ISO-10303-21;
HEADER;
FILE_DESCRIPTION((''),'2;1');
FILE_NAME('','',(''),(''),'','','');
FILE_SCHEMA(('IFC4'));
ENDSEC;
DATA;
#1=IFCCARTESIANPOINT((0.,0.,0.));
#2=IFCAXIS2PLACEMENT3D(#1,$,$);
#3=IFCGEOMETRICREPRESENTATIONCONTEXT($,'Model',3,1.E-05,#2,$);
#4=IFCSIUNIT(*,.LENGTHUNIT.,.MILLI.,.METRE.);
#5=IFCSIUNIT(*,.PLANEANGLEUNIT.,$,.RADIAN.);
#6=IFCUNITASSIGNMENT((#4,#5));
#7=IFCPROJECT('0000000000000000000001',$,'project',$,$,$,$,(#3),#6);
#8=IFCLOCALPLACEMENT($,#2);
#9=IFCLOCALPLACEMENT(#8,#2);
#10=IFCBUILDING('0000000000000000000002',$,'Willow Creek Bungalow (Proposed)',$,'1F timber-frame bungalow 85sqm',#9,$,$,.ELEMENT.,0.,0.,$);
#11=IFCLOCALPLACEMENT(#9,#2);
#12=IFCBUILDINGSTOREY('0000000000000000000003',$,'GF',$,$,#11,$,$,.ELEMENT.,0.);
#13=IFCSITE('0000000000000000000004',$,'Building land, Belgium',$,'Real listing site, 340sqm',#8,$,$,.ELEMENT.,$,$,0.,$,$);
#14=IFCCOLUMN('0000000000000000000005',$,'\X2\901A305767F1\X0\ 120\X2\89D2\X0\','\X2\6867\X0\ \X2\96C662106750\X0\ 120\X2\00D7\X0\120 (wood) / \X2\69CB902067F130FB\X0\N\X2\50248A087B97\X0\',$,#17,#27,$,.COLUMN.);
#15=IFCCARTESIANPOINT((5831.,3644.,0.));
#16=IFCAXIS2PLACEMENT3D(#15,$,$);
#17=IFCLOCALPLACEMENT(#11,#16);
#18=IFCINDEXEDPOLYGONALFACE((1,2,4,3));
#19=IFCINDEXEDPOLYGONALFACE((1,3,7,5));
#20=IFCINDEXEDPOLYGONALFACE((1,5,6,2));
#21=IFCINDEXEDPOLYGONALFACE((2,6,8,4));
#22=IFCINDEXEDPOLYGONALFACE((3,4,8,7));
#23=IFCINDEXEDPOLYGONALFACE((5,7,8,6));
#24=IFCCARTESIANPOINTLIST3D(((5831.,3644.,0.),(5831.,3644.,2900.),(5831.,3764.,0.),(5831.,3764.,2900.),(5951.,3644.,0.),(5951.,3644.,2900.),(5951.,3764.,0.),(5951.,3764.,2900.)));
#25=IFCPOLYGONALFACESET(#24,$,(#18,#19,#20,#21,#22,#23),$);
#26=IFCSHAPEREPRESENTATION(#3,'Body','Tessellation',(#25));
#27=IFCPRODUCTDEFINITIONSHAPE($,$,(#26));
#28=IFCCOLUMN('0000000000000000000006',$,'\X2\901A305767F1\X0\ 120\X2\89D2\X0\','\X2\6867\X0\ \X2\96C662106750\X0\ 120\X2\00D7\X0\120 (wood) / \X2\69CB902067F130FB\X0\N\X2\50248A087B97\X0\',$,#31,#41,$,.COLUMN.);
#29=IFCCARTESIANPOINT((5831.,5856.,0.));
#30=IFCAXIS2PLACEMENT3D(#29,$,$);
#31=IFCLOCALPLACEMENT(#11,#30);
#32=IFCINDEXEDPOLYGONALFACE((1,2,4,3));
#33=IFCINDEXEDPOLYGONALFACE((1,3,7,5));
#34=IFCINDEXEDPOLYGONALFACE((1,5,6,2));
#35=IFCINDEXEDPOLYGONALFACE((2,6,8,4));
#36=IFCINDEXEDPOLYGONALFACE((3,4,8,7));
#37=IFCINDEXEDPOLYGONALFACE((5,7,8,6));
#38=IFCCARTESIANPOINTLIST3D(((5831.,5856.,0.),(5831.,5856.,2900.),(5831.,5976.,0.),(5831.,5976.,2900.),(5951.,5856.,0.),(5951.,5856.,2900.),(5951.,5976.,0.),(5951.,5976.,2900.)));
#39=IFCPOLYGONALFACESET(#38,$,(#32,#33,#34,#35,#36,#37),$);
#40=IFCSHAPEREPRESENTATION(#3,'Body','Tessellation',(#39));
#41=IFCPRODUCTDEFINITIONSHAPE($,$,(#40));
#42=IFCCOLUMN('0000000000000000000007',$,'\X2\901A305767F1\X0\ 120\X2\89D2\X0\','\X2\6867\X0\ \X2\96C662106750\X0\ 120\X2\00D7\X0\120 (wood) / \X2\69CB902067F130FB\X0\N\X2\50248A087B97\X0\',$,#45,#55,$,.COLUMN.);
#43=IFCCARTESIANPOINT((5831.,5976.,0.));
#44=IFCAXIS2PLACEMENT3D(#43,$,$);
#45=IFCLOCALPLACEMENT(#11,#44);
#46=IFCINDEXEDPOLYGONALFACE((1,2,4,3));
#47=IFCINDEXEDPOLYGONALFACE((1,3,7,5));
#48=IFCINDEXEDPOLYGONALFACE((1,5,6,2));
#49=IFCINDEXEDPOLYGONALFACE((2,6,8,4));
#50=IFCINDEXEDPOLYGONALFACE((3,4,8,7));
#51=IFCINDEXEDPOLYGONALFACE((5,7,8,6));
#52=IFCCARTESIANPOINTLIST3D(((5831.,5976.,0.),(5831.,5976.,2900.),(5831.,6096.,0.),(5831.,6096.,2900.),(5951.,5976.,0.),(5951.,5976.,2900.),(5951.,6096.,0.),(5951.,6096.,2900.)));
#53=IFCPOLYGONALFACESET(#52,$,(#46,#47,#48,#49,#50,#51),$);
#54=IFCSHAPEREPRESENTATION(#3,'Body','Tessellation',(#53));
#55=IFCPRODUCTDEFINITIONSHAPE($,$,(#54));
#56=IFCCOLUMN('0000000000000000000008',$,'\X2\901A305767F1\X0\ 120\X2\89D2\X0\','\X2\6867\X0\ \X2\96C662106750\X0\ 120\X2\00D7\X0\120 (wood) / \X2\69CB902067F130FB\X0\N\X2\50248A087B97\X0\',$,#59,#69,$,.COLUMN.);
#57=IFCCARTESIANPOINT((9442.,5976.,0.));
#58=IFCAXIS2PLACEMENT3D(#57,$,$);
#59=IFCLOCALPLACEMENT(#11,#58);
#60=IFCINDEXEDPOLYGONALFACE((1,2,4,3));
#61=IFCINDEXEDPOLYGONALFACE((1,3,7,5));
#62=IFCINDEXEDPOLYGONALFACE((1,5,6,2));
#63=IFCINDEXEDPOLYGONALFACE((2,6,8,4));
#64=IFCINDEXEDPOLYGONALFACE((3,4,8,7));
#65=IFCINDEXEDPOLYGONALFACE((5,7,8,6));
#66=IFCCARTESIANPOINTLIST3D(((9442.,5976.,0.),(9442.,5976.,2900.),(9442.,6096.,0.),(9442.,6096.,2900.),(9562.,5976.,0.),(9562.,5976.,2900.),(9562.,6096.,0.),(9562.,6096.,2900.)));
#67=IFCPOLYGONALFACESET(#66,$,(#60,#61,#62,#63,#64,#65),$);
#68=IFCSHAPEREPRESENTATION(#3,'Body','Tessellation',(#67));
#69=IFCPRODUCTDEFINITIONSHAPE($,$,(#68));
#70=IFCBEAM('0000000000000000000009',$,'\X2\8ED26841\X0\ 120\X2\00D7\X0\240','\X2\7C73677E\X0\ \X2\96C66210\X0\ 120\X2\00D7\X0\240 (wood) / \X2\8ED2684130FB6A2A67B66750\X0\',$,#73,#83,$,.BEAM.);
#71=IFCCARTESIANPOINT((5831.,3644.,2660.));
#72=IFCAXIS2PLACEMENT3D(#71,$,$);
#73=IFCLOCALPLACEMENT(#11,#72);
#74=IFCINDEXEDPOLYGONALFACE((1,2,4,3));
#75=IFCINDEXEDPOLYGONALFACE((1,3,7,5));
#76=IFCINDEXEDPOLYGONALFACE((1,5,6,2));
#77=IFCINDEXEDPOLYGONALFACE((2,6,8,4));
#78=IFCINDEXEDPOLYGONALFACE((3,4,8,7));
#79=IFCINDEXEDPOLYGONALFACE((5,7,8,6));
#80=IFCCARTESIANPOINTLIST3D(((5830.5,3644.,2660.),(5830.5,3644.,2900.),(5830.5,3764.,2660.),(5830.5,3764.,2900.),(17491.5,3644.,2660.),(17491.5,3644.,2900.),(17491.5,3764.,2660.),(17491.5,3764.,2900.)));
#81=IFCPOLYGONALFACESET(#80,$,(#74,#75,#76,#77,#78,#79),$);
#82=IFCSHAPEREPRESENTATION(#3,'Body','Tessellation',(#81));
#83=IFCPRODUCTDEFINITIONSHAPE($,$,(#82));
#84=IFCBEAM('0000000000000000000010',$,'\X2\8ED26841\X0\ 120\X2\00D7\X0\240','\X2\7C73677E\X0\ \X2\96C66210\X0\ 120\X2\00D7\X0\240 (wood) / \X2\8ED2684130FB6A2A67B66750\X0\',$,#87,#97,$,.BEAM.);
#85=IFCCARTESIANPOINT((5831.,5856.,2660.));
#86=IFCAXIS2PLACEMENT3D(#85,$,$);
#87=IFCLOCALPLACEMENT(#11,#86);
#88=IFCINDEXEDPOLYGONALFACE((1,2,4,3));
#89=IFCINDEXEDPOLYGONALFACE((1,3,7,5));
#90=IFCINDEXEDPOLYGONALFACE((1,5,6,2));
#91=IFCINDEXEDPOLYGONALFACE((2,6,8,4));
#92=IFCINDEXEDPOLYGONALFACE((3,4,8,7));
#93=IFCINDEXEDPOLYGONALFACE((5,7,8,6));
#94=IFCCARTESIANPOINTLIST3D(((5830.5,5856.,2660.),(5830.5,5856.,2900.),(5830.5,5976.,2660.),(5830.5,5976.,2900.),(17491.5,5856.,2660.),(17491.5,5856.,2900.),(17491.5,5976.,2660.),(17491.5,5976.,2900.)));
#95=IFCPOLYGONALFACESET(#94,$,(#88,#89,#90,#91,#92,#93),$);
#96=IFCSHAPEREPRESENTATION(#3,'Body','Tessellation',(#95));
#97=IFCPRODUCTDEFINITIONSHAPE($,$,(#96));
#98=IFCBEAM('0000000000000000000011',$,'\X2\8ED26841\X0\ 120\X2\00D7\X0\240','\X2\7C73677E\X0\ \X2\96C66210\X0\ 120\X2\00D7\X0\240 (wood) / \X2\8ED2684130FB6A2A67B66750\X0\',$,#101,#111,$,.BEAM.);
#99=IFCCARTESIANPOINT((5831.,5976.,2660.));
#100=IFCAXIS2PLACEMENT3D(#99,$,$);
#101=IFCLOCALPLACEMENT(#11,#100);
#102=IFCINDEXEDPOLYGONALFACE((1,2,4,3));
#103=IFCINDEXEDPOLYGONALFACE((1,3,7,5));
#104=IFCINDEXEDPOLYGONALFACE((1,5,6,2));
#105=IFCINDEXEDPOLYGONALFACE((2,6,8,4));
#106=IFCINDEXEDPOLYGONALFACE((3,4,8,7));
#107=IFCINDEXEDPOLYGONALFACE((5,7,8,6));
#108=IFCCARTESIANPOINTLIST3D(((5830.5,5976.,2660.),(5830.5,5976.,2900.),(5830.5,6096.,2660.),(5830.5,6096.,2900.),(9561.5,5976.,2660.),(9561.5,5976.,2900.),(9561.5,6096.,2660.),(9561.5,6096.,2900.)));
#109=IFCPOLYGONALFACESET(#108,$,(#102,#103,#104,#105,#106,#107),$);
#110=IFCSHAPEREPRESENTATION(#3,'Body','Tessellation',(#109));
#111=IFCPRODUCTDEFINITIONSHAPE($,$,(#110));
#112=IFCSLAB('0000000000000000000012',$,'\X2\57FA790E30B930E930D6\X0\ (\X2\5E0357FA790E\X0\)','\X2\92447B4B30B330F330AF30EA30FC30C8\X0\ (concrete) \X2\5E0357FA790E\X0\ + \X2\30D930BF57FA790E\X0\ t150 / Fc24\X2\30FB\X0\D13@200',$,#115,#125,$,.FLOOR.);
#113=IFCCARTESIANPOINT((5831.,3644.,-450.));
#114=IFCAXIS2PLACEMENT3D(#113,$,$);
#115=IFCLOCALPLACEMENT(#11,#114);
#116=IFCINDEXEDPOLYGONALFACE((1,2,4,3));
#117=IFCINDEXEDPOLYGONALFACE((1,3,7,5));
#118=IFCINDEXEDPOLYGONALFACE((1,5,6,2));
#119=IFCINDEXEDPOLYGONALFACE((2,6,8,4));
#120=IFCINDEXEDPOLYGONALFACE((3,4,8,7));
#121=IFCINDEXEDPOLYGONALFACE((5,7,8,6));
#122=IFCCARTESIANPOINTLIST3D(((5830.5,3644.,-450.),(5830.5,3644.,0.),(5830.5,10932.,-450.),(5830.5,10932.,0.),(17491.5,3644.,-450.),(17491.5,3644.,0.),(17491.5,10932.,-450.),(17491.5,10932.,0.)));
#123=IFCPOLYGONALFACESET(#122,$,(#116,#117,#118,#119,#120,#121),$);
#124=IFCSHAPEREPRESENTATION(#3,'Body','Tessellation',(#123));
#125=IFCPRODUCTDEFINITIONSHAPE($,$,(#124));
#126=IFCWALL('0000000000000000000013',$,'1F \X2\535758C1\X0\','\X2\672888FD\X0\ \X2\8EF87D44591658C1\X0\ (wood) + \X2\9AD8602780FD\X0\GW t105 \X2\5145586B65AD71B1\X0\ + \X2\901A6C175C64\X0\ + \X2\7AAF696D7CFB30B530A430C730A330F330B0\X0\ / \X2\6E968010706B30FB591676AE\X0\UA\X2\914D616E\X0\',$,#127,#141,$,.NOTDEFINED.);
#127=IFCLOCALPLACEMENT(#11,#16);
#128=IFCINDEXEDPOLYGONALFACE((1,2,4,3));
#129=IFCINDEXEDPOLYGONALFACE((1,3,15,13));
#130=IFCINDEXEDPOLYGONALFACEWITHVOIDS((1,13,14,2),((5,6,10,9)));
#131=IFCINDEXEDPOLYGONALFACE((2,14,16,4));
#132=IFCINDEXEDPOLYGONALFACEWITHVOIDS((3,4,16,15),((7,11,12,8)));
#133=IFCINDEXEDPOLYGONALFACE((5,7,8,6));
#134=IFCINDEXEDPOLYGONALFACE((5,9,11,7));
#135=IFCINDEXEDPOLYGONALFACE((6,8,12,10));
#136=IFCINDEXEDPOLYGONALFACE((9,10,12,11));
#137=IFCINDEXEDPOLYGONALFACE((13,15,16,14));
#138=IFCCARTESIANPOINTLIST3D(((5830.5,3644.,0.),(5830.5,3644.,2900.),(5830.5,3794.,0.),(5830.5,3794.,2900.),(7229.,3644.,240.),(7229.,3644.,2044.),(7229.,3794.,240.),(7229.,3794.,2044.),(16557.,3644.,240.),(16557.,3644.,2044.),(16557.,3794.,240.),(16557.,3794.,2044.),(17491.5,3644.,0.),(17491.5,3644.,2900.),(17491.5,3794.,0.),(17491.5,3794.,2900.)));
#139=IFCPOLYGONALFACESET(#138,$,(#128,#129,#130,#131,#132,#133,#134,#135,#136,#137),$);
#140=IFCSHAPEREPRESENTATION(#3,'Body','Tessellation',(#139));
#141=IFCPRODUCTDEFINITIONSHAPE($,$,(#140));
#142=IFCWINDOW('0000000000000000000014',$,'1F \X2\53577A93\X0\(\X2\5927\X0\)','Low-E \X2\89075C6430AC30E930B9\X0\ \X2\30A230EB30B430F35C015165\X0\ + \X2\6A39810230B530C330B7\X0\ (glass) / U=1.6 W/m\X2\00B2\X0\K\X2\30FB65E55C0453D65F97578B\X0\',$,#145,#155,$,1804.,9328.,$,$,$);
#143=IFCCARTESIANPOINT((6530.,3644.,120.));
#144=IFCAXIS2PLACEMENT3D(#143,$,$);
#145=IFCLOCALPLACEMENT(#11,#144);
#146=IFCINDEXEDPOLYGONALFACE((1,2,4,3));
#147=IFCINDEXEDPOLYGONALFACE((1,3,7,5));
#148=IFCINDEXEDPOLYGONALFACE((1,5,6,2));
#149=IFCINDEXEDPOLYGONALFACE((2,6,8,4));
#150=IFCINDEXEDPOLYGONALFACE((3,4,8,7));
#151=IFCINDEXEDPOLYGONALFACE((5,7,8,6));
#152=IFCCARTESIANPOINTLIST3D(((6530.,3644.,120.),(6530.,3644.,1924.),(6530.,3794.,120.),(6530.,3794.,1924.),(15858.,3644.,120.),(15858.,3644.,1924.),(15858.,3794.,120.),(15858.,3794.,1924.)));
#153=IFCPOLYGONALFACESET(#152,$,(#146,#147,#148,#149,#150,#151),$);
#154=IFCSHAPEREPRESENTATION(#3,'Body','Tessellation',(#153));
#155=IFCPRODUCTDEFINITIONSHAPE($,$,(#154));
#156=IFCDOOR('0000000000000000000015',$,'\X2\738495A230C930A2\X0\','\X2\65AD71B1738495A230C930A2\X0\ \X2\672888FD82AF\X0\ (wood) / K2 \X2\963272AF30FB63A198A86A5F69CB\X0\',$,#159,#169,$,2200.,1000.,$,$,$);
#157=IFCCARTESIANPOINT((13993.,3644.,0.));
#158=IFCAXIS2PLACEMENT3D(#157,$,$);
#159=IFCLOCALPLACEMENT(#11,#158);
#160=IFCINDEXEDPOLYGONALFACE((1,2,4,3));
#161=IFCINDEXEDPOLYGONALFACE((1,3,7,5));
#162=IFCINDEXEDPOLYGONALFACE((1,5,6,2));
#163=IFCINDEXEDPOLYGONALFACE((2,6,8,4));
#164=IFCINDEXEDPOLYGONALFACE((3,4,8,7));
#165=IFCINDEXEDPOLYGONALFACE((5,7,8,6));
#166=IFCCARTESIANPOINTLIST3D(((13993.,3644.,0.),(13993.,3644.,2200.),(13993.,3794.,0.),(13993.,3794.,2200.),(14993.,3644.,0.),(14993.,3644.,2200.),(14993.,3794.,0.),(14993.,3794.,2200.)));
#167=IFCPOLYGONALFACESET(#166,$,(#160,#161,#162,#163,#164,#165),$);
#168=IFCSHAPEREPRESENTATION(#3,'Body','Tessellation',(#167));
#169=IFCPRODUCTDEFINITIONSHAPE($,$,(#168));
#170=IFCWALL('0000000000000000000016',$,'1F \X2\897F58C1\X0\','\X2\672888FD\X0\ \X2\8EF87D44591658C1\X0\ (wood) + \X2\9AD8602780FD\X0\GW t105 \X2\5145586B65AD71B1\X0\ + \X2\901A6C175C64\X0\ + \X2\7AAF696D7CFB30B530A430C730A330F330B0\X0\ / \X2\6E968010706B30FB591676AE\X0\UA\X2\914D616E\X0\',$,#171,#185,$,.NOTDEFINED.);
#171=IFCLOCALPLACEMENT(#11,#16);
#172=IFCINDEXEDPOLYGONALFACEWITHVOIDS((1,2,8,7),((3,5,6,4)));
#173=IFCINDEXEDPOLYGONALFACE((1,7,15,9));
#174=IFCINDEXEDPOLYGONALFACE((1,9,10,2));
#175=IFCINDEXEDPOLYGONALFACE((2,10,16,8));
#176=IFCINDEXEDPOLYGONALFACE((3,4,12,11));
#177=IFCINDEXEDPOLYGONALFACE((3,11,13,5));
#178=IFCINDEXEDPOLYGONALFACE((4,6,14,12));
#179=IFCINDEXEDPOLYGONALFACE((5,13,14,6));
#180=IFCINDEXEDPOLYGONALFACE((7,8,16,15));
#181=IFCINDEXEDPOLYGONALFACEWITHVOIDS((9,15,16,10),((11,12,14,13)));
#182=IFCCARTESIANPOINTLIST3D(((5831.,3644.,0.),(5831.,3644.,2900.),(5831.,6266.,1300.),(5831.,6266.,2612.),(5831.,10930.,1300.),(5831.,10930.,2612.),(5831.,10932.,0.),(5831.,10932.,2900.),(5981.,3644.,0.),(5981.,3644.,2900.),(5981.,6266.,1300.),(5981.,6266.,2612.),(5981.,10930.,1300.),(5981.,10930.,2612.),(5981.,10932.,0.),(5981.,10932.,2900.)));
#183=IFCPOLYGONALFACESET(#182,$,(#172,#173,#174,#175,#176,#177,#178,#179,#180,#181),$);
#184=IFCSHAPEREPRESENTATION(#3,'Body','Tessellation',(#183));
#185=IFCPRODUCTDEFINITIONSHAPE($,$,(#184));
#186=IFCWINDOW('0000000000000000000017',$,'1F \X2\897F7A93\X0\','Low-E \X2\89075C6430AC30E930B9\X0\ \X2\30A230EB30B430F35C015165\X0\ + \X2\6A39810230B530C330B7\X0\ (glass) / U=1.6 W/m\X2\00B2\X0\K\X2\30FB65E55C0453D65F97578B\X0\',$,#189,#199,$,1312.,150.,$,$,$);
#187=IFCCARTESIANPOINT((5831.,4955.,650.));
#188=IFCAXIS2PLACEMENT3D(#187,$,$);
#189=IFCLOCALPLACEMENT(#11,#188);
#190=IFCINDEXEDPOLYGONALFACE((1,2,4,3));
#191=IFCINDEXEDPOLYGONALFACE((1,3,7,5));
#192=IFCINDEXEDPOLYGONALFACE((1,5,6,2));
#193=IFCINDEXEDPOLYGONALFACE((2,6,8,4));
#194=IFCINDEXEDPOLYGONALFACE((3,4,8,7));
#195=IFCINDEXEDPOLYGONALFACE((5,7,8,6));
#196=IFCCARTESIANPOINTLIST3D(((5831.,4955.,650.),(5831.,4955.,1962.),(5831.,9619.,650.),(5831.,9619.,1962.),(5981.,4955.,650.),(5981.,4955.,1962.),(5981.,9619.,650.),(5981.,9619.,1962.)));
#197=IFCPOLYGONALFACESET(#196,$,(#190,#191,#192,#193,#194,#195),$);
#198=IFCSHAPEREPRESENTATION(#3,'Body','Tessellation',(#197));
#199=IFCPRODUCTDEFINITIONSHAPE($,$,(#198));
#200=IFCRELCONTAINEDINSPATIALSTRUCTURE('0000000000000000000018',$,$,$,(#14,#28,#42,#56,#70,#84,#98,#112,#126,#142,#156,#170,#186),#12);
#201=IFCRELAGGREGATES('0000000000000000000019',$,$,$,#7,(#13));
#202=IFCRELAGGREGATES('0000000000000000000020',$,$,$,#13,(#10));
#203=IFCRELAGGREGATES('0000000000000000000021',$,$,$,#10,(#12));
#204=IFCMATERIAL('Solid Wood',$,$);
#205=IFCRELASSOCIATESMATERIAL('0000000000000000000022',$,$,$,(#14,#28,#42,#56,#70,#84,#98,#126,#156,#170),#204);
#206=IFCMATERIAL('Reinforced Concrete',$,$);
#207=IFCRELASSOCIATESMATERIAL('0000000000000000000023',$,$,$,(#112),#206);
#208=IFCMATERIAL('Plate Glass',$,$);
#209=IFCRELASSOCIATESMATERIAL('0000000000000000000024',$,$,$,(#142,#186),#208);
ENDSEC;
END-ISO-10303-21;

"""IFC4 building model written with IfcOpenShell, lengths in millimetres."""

from ifc_helpers import new_model, si_unit, frame, frame_2d, origin, place, context, project, spatial, rectangle, extrude, material, element, fill, save


model = new_model("IFC4")

# Units and contexts
model_context = context("Model", 3, precision=1e-05, world=origin())
ifc_project = project(units=[si_unit("LENGTHUNIT", "METRE", prefix="MILLI"), si_unit("PLANEANGLEUNIT", "RADIAN")], contexts=[model_context])

# Site, building, storey
site_placement = place(None, origin())
site = spatial("IfcSite", under=ifc_project, at=site_placement, Name="Building land, Belgium", ObjectType="Real listing site, 340sqm", CompositionType="ELEMENT", RefElevation=0.0)
building_placement = place(site_placement, origin())
building = spatial("IfcBuilding", under=site, at=building_placement, Name="Willow Creek Bungalow (Proposed)", ObjectType="1F timber-frame bungalow 85sqm", CompositionType="ELEMENT", ElevationOfRefHeight=0.0, ElevationOfTerrain=0.0)
storey_placement = place(building_placement, origin())
storey = spatial("IfcBuildingStorey", under=building, at=storey_placement, Name="GF", CompositionType="ELEMENT", Elevation=0.0)

# Columns
ifc_material_1 = material(Name="Solid Wood")
column_1_placement = place(storey_placement, frame((5831.0, 3644.0, 0.0)))
element("IfcColumn", 1, at=column_1_placement, inside=storey, material=ifc_material_1, Name="通し柱 120角", Description="桧 集成材 120×120 (wood) / 構造柱・N値計算", PredefinedType="COLUMN", context=model_context, shape_type="SweptSolid", body=[
    extrude(rectangle(XDim=120.0, YDim=120.0, at=frame_2d((60.0, 60.0))), frame((5831.0, 3644.0, 0.0)), (0.0, 0.0, 1.0), 2900.0),
])
column_2_placement = place(storey_placement, frame((5831.0, 5856.0, 0.0)))
element("IfcColumn", 2, at=column_2_placement, inside=storey, material=ifc_material_1, Name="通し柱 120角", Description="桧 集成材 120×120 (wood) / 構造柱・N値計算", PredefinedType="COLUMN", context=model_context, shape_type="SweptSolid", body=[
    extrude(rectangle(XDim=120.0, YDim=120.0, at=frame_2d((60.0, 60.0))), frame((5831.0, 5856.0, 0.0)), (0.0, 0.0, 1.0), 2900.0),
])
column_3_placement = place(storey_placement, frame((5831.0, 5976.0, 0.0)))
element("IfcColumn", 3, at=column_3_placement, inside=storey, material=ifc_material_1, Name="通し柱 120角", Description="桧 集成材 120×120 (wood) / 構造柱・N値計算", PredefinedType="COLUMN", context=model_context, shape_type="SweptSolid", body=[
    extrude(rectangle(XDim=120.0, YDim=120.0, at=frame_2d((60.0, 60.0))), frame((5831.0, 5976.0, 0.0)), (0.0, 0.0, 1.0), 2900.0),
])
column_4_placement = place(storey_placement, frame((9442.0, 5976.0, 0.0)))
element("IfcColumn", 4, at=column_4_placement, inside=storey, material=ifc_material_1, Name="通し柱 120角", Description="桧 集成材 120×120 (wood) / 構造柱・N値計算", PredefinedType="COLUMN", context=model_context, shape_type="SweptSolid", body=[
    extrude(rectangle(XDim=120.0, YDim=120.0, at=frame_2d((60.0, 60.0))), frame((9442.0, 5976.0, 0.0)), (0.0, 0.0, 1.0), 2900.0),
])

# Beams
beam_1_placement = place(storey_placement, frame((5831.0, 3644.0, 2660.0)))
element("IfcBeam", 5, at=beam_1_placement, inside=storey, material=ifc_material_1, Name="軒桁 120×240", Description="米松 集成 120×240 (wood) / 軒桁・横架材", PredefinedType="BEAM", context=model_context, shape_type="SweptSolid", body=[
    extrude(rectangle(XDim=11661.0, YDim=120.0, at=frame_2d((5830.0, 60.0))), frame((5831.0, 3644.0, 2660.0)), (0.0, 0.0, 1.0), 240.0),
])
beam_2_placement = place(storey_placement, frame((5831.0, 5856.0, 2660.0)))
element("IfcBeam", 6, at=beam_2_placement, inside=storey, material=ifc_material_1, Name="軒桁 120×240", Description="米松 集成 120×240 (wood) / 軒桁・横架材", PredefinedType="BEAM", context=model_context, shape_type="SweptSolid", body=[
    extrude(rectangle(XDim=11661.0, YDim=120.0, at=frame_2d((5830.0, 60.0))), frame((5831.0, 5856.0, 2660.0)), (0.0, 0.0, 1.0), 240.0),
])
beam_3_placement = place(storey_placement, frame((5831.0, 5976.0, 2660.0)))
element("IfcBeam", 7, at=beam_3_placement, inside=storey, material=ifc_material_1, Name="軒桁 120×240", Description="米松 集成 120×240 (wood) / 軒桁・横架材", PredefinedType="BEAM", context=model_context, shape_type="SweptSolid", body=[
    extrude(rectangle(XDim=3731.0, YDim=120.0, at=frame_2d((1865.0, 60.0))), frame((5831.0, 5976.0, 2660.0)), (0.0, 0.0, 1.0), 240.0),
])

# Slab
ifc_material_2 = material(Name="Reinforced Concrete")
slab_1_placement = place(storey_placement, frame((5831.0, 3644.0, -450.0)))
element("IfcSlab", 8, at=slab_1_placement, inside=storey, material=ifc_material_2, Name="基礎スラブ (布基礎)", Description="鉄筋コンクリート (concrete) 布基礎 + ベタ基礎 t150 / Fc24・D13@200", PredefinedType="FLOOR", context=model_context, shape_type="SweptSolid", body=[
    extrude(rectangle(XDim=11661.0, YDim=7288.0, at=frame_2d((5830.0, 3644.0))), frame((5831.0, 3644.0, -450.0)), (0.0, 0.0, 1.0), 450.0),
])

# Wall, openings, window, door
wall_1_placement = place(storey_placement, frame((5831.0, 3644.0, 0.0)))
wall_1 = element("IfcWall", 9, at=wall_1_placement, inside=storey, material=ifc_material_1, Name="1F 南壁", Description="木製 軸組外壁 (wood) + 高性能GW t105 充填断熱 + 通気層 + 窯業系サイディング / 準耐火・外皮UA配慮", PredefinedType="NOTDEFINED", context=model_context, shape_type="SweptSolid", body=[
    extrude(rectangle(XDim=11661.0, YDim=150.0, at=frame_2d((5830.0, 75.0))), frame((5831.0, 3644.0, 0.0)), (0.0, 0.0, 1.0), 2900.0),
])
opening_1_placement = place(storey_placement, frame((6530.0, 3644.0, 120.0)))
opening_1 = element("IfcOpeningElement", 10, at=opening_1_placement, cuts=wall_1, PredefinedType="NOTDEFINED", context=model_context, shape_type="SweptSolid", body=[
    extrude(rectangle(XDim=9328.0, YDim=150.0, at=frame_2d((4664.0, 75.0))), frame((6530.0, 3644.0, 120.0)), (0.0, 0.0, 1.0), 1804.0),
])
opening_2_placement = place(storey_placement, frame((13993.0, 3644.0, 0.0)))
opening_2 = element("IfcOpeningElement", 11, at=opening_2_placement, cuts=wall_1, PredefinedType="NOTDEFINED", context=model_context, shape_type="SweptSolid", body=[
    extrude(rectangle(XDim=1000.0, YDim=150.0, at=frame_2d((500.0, 75.0))), frame((13993.0, 3644.0, 0.0)), (0.0, 0.0, 1.0), 2200.0),
])
ifc_material_3 = material(Name="Plate Glass")
window_1_placement = place(storey_placement, frame((6530.0, 3644.0, 120.0)))
window_1 = element("IfcWindow", 12, at=window_1_placement, inside=storey, material=ifc_material_3, Name="1F 南窓(大)", Description="Low-E 複層ガラス アルゴン封入 + 樹脂サッシ (glass) / U=1.6 W/m²K・日射取得型", OverallHeight=1804.0, OverallWidth=9328.0, context=model_context, shape_type="SweptSolid", body=[
    extrude(rectangle(XDim=9328.0, YDim=150.0, at=frame_2d((4664.0, 75.0))), frame((6530.0, 3644.0, 120.0)), (0.0, 0.0, 1.0), 1804.0),
])
fill(opening_1, window_1)
door_placement = place(storey_placement, frame((13993.0, 3644.0, 0.0)))
door = element("IfcDoor", 13, at=door_placement, inside=storey, material=ifc_material_1, Name="玄関ドア", Description="断熱玄関ドア 木製芯 (wood) / K2 防犯・採風機構", OverallHeight=2200.0, OverallWidth=1000.0, context=model_context, shape_type="SweptSolid", body=[
    extrude(rectangle(XDim=1000.0, YDim=150.0, at=frame_2d((500.0, 75.0))), frame((13993.0, 3644.0, 0.0)), (0.0, 0.0, 1.0), 2200.0),
])
fill(opening_2, door)

# Wall, opening, window
wall_2_placement = place(storey_placement, frame((5831.0, 3644.0, 0.0)))
wall_2 = element("IfcWall", 14, at=wall_2_placement, inside=storey, material=ifc_material_1, Name="1F 西壁", Description="木製 軸組外壁 (wood) + 高性能GW t105 充填断熱 + 通気層 + 窯業系サイディング / 準耐火・外皮UA配慮", PredefinedType="NOTDEFINED", context=model_context, shape_type="SweptSolid", body=[
    extrude(rectangle(XDim=150.0, YDim=7288.0, at=frame_2d((75.0, 3644.0))), frame((5831.0, 3644.0, 0.0)), (0.0, 0.0, 1.0), 2900.0),
])
opening_3_placement = place(storey_placement, frame((5831.0, 4955.0, 650.0)))
opening_3 = element("IfcOpeningElement", 15, at=opening_3_placement, cuts=wall_2, PredefinedType="NOTDEFINED", context=model_context, shape_type="SweptSolid", body=[
    extrude(rectangle(XDim=150.0, YDim=4664.0, at=frame_2d((75.0, 2332.0))), frame((5831.0, 4955.0, 650.0)), (0.0, 0.0, 1.0), 1312.0),
])
window_2_placement = place(storey_placement, frame((5831.0, 4955.0, 650.0)))
window_2 = element("IfcWindow", 16, at=window_2_placement, inside=storey, material=ifc_material_3, Name="1F 西窓", Description="Low-E 複層ガラス アルゴン封入 + 樹脂サッシ (glass) / U=1.6 W/m²K・日射取得型", OverallHeight=1312.0, OverallWidth=150.0, context=model_context, shape_type="SweptSolid", body=[
    extrude(rectangle(XDim=150.0, YDim=4664.0, at=frame_2d((75.0, 2332.0))), frame((5831.0, 4955.0, 650.0)), (0.0, 0.0, 1.0), 1312.0),
])
fill(opening_3, window_2)

save(model, "model.ifc")
